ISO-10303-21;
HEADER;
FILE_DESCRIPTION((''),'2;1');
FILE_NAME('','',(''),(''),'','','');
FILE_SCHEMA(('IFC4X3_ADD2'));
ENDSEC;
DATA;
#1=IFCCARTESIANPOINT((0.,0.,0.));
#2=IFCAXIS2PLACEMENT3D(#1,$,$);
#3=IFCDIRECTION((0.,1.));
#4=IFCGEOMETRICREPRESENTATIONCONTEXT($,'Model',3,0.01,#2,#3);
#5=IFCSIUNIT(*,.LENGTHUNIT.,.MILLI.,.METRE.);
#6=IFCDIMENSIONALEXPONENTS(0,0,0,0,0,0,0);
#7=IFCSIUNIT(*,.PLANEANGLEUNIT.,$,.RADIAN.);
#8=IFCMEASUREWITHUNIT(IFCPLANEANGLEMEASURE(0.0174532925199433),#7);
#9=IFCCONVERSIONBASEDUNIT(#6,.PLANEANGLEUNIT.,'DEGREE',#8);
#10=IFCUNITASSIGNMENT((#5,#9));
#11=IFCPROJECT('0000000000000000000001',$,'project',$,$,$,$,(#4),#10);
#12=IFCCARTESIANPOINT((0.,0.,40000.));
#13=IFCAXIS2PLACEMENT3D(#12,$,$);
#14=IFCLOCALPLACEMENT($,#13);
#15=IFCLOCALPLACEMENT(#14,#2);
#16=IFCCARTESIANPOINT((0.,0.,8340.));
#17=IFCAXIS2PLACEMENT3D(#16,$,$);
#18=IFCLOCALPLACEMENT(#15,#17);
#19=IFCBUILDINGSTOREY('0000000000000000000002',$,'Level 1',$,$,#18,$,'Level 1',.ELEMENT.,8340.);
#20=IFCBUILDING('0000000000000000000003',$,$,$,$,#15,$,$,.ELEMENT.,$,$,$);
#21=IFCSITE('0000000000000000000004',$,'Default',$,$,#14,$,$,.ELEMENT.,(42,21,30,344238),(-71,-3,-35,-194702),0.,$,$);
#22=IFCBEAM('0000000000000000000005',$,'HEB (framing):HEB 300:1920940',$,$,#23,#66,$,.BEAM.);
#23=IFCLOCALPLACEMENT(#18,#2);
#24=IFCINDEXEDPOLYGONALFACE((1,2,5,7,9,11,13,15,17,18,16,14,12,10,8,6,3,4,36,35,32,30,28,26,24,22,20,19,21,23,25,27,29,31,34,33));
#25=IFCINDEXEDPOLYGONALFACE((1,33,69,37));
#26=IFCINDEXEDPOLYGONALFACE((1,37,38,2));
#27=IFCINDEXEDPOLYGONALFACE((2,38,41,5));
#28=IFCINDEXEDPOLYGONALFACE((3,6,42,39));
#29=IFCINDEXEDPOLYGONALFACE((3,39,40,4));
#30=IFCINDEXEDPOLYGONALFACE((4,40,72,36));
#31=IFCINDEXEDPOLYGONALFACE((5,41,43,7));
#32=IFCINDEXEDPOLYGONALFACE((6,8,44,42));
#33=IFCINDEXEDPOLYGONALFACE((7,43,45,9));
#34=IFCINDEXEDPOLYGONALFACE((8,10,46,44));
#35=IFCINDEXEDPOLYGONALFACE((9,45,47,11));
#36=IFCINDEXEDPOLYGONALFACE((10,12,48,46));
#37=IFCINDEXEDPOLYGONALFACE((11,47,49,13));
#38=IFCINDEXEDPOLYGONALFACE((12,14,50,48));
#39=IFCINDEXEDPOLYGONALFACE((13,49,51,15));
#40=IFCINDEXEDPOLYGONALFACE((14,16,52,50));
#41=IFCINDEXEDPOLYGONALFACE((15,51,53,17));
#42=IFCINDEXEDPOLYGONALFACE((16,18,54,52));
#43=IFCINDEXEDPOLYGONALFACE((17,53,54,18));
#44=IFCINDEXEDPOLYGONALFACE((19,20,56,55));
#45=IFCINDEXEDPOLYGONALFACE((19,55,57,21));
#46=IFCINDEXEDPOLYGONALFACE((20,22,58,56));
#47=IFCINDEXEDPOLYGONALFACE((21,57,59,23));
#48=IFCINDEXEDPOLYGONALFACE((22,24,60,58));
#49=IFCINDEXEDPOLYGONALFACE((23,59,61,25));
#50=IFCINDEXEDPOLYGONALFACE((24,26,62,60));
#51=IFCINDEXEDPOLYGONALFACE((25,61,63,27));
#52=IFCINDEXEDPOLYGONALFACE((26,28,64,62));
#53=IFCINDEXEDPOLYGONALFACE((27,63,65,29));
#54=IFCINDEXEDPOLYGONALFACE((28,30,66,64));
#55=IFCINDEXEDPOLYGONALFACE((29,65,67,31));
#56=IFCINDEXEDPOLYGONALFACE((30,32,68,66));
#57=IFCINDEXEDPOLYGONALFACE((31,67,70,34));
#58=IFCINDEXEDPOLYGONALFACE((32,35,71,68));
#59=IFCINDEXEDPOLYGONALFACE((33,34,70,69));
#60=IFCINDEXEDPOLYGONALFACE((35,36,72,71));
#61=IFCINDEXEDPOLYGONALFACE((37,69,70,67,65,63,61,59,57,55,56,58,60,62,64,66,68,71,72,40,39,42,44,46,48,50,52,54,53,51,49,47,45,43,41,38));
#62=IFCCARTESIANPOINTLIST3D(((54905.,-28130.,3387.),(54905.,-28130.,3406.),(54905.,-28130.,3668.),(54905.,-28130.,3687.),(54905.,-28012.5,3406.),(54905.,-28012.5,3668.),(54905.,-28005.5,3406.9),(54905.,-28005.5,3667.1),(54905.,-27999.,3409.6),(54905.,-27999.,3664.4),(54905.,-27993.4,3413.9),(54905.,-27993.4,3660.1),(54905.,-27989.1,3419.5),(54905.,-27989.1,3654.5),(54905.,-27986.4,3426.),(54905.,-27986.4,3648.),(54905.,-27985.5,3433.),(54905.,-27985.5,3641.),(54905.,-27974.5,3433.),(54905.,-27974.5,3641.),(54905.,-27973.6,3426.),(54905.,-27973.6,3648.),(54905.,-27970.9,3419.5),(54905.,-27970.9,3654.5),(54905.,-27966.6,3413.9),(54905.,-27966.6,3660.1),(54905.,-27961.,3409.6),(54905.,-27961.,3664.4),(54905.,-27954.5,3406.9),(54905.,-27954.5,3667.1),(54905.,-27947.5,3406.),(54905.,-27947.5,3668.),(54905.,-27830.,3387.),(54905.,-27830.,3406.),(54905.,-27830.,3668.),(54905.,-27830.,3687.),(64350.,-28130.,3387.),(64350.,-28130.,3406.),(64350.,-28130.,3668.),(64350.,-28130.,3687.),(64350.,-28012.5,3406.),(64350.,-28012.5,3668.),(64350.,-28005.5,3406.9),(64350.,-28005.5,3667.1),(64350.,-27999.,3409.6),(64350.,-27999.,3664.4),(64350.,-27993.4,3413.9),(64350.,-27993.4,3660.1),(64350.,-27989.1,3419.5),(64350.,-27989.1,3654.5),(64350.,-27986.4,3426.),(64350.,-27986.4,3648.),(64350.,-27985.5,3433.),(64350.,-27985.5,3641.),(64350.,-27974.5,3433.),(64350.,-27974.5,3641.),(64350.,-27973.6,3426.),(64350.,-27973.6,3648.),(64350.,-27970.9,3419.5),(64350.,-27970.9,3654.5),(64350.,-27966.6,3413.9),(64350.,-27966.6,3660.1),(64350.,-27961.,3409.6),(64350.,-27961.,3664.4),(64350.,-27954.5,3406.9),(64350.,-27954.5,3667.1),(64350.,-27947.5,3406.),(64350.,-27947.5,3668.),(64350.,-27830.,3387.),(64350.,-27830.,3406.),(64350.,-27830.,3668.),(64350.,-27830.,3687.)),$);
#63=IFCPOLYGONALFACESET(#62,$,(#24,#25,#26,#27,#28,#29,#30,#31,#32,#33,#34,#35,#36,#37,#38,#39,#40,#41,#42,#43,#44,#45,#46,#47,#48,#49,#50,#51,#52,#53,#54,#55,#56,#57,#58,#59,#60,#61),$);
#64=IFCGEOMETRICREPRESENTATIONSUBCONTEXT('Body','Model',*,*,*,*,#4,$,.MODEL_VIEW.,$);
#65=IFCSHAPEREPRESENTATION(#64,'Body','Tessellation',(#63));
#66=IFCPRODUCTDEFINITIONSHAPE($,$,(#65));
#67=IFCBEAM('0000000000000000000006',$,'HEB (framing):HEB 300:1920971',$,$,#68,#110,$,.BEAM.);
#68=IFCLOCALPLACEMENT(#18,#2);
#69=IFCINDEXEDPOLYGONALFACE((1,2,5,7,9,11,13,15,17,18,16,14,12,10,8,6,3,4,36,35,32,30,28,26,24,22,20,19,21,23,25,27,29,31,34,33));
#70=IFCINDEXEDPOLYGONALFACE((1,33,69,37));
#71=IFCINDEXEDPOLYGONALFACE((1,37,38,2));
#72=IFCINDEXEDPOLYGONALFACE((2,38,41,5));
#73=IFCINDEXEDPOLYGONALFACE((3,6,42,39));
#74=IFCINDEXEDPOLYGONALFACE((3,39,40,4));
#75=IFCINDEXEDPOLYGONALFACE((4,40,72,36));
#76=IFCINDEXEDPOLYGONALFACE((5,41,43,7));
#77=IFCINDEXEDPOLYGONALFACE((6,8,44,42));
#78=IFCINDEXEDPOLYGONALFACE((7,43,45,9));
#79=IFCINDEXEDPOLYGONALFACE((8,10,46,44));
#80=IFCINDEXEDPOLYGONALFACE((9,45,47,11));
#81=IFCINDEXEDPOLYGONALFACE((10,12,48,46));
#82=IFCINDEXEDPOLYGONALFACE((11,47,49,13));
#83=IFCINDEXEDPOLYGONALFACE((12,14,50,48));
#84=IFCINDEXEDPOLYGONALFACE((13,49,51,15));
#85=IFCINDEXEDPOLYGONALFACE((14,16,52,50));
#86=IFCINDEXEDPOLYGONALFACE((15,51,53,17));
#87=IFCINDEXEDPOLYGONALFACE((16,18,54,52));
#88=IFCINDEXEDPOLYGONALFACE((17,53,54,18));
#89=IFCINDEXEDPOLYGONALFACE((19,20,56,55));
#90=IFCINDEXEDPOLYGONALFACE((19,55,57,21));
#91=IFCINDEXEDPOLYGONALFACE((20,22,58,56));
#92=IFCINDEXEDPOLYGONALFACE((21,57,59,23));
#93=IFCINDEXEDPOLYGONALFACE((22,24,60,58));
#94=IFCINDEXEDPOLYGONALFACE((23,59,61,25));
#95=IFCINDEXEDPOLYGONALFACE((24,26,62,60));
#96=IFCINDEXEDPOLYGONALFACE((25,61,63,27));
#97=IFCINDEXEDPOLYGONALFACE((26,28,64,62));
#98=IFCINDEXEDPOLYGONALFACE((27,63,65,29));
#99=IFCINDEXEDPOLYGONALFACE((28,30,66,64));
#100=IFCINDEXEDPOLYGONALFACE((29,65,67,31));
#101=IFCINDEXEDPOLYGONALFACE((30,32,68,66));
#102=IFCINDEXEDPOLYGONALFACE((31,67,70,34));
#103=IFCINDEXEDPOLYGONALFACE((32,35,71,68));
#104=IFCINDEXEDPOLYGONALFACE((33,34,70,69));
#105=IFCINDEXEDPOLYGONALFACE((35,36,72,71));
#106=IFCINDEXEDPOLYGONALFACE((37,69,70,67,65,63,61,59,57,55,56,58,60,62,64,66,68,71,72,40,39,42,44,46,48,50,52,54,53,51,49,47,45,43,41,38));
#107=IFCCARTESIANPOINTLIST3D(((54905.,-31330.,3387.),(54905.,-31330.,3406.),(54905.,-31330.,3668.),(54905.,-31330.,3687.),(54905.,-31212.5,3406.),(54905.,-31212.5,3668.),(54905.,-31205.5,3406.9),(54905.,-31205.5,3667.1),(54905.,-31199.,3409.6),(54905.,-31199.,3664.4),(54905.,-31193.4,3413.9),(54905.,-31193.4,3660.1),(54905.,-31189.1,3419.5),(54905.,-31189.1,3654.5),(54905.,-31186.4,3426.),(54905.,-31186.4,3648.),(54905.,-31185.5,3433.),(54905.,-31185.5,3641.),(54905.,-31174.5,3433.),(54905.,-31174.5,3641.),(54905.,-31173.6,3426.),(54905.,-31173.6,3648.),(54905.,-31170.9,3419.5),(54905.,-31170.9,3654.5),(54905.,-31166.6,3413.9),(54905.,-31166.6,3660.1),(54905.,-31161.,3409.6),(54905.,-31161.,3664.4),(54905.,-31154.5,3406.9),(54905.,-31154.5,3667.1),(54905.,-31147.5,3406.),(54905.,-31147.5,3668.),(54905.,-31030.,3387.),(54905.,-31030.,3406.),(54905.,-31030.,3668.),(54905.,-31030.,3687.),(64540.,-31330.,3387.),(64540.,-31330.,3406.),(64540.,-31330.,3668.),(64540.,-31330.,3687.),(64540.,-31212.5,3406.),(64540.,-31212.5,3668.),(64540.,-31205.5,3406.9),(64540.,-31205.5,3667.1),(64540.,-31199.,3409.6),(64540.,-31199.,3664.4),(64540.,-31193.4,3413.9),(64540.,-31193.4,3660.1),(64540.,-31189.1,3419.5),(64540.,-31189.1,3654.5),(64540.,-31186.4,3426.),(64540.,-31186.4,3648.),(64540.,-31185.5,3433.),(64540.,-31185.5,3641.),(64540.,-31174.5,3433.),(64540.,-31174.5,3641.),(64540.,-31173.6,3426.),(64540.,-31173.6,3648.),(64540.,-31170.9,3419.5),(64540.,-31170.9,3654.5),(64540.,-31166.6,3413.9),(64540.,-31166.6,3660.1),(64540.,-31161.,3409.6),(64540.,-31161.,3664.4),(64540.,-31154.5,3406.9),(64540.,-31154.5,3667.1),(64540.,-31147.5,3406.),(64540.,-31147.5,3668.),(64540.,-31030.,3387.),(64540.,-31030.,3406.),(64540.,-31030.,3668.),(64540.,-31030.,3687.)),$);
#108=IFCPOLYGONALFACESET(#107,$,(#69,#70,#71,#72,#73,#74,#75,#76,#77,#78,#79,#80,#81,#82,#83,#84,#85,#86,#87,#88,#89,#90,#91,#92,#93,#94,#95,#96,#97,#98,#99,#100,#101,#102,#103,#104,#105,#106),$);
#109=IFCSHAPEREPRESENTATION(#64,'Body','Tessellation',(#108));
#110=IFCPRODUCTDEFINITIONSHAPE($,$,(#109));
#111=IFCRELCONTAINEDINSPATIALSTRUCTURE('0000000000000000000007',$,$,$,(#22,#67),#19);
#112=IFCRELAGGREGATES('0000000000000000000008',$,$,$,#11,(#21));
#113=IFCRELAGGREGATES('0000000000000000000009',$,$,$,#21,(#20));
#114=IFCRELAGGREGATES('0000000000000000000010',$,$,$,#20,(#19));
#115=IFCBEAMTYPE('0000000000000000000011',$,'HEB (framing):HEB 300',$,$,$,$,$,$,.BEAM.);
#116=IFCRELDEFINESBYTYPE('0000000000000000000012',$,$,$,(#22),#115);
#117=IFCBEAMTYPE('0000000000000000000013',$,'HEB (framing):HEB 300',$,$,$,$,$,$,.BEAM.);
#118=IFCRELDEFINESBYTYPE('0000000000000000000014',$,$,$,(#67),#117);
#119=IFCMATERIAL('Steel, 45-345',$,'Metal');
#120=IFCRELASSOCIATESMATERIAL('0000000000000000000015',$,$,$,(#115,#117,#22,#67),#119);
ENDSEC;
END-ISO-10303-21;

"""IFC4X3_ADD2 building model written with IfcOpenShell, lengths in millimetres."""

from ifc_helpers import new_model, entity, si_unit, converted_unit, direction, frame, frame_2d, origin, place, context, subcontext, project, spatial, polyline, circle_curve, parameter, trimmed, segment, composite_curve, outline, extrude, source, transform, mapped, material, material_profile, profile_set, profile_usage, type_object, type_shapes, element, save


model = new_model("IFC4X3_ADD2")

# Units and contexts
model_context = context("Model", 3, precision=0.01, world=origin(), true_north=direction((0.0, 1.0)))
body_context = subcontext(model_context, "Body", "Model", "MODEL_VIEW")
ifc_project = project(units=[si_unit("LENGTHUNIT", "METRE", prefix="MILLI"), converted_unit("PLANEANGLEUNIT", "DEGREE", entity("IfcPlaneAngleMeasure", 0.0174532925199433), si_unit("PLANEANGLEUNIT", "RADIAN"), dimensions=[0, 0, 0, 0, 0, 0, 0])], contexts=[model_context])

# Site, building, storey
site_placement = place(None, frame((0.0, 0.0, 40000.0)))
site = spatial("IfcSite", under=ifc_project, at=site_placement, Name="Default", CompositionType="ELEMENT", RefLatitude=(42, 21, 30, 344238), RefLongitude=(-71, -3, -35, -194702), RefElevation=0.0)
building_placement = place(site_placement, origin())
building = spatial("IfcBuilding", under=site, at=building_placement, CompositionType="ELEMENT")
storey_placement = place(building_placement, frame((0.0, 0.0, 8340.0)))
storey = spatial("IfcBuildingStorey", under=building, at=storey_placement, Name="Level 1", LongName="Level 1", CompositionType="ELEMENT", Elevation=8340.0)

# Shared definitions
ifc_material_1 = material(Name="Steel, 45-345", Category="Metal")

# Beams
ifc_material_profile_1 = material_profile(ifc_material_1, outline(composite_curve([segment(polyline([(-150.0, -131.0), (-150.0, -150.0)]), True, "CONTINUOUS"), segment(polyline([(-150.0, -150.0), (150.0, -150.0)]), True, "CONTINUOUS"), segment(polyline([(150.0, -150.0), (150.0, -131.0)]), True, "CONTINUOUS"), segment(polyline([(150.0, -131.0), (32.5, -131.0)]), True, "CONTINUOUS"), segment(trimmed(circle_curve(frame_2d((32.5, -104.0), x_axis=(1.0, 0.0)), 27.0), [parameter(180.0)], [parameter(270.0)], True, "PARAMETER"), False, "CONTINUOUS"), segment(polyline([(5.5, -104.0), (5.5, 104.0)]), True, "CONTINUOUS"), segment(trimmed(circle_curve(frame_2d((32.5, 104.0), x_axis=(1.0, 0.0)), 27.0), [parameter(90.0)], [parameter(180.0)], True, "PARAMETER"), False, "CONTINUOUS"), segment(polyline([(32.5, 131.0), (150.0, 131.0)]), True, "CONTINUOUS"), segment(polyline([(150.0, 131.0), (150.0, 150.0)]), True, "CONTINUOUS"), segment(polyline([(150.0, 150.0), (-150.0, 150.0)]), True, "CONTINUOUS"), segment(polyline([(-150.0, 150.0), (-150.0, 131.0)]), True, "CONTINUOUS"), segment(polyline([(-150.0, 131.0), (-32.5, 131.0)]), True, "CONTINUOUS"), segment(trimmed(circle_curve(frame_2d((-32.5, 104.0), x_axis=(1.0, 0.0)), 27.0), [parameter(360.0)], [parameter(90.0)], True, "PARAMETER"), False, "CONTINUOUS"), segment(polyline([(-5.5, 104.0), (-5.5, -104.0)]), True, "CONTINUOUS"), segment(trimmed(circle_curve(frame_2d((-32.5, -104.0), x_axis=(1.0, 0.0)), 27.0), [parameter(270.0)], [parameter(0.0)], True, "PARAMETER"), False, "CONTINUOUS"), segment(polyline([(-32.5, -131.0), (-150.0, -131.0)]), True, "CONTINUOUS")], self_intersect=False)), Name="HEB 300")
ifc_profile_set_1 = profile_set([ifc_material_profile_1], Name="HEB 300")
ifc_profile_usage_1 = profile_usage(ifc_profile_set_1, cardinal=8)
beam_type_1 = type_object("IfcBeamType", Name="HEB (framing):HEB 300", PredefinedType="BEAM", material=ifc_profile_set_1)
shared_shape_1 = source(origin(), body_context, "Body", "SweptSolid", [
    extrude(outline(composite_curve([segment(polyline([(-150.0, -131.0), (-150.0, -150.0)]), True, "CONTINUOUS"), segment(polyline([(-150.0, -150.0), (150.0, -150.0)]), True, "CONTINUOUS"), segment(polyline([(150.0, -150.0), (150.0, -131.0)]), True, "CONTINUOUS"), segment(polyline([(150.0, -131.0), (32.5, -131.0)]), True, "CONTINUOUS"), segment(trimmed(circle_curve(frame_2d((32.5, -104.0), x_axis=(1.0, 0.0)), 27.0), [parameter(180.0)], [parameter(270.0)], True, "PARAMETER"), False, "CONTINUOUS"), segment(polyline([(5.5, -104.0), (5.5, 104.0)]), True, "CONTINUOUS"), segment(trimmed(circle_curve(frame_2d((32.5, 104.0), x_axis=(1.0, 0.0)), 27.0), [parameter(90.0)], [parameter(180.0)], True, "PARAMETER"), False, "CONTINUOUS"), segment(polyline([(32.5, 131.0), (150.0, 131.0)]), True, "CONTINUOUS"), segment(polyline([(150.0, 131.0), (150.0, 150.0)]), True, "CONTINUOUS"), segment(polyline([(150.0, 150.0), (-150.0, 150.0)]), True, "CONTINUOUS"), segment(polyline([(-150.0, 150.0), (-150.0, 131.0)]), True, "CONTINUOUS"), segment(polyline([(-150.0, 131.0), (-32.5, 131.0)]), True, "CONTINUOUS"), segment(trimmed(circle_curve(frame_2d((-32.5, 104.0), x_axis=(1.0, 0.0)), 27.0), [parameter(360.0)], [parameter(90.0)], True, "PARAMETER"), False, "CONTINUOUS"), segment(polyline([(-5.5, 104.0), (-5.5, -104.0)]), True, "CONTINUOUS"), segment(trimmed(circle_curve(frame_2d((-32.5, -104.0), x_axis=(1.0, 0.0)), 27.0), [parameter(270.0)], [parameter(0.0)], True, "PARAMETER"), False, "CONTINUOUS"), segment(polyline([(-32.5, -131.0), (-150.0, -131.0)]), True, "CONTINUOUS")], self_intersect=False)), frame((-4697.5, 0.0, 0.0), z_axis=(-1.0, 0.0, 0.0), x_axis=(0.0, -1.0, 0.0)), (0.0, 0.0, -1.0), 9445.0),
])
type_shapes(beam_type_1, [shared_shape_1])
beam_1_placement = place(storey_placement, frame((59602.5, -27980.0, 3537.0)))
element("IfcBeam", 1, at=beam_1_placement, inside=storey, type_object=beam_type_1, material=ifc_profile_usage_1, Name="HEB (framing):HEB 300:1920940", PredefinedType="BEAM", context=body_context, shape_type="MappedRepresentation", body=[
    mapped(shared_shape_1, transform((0.0, 0.0, 0.0), scale=1.0)),
])
beam_type_2 = type_object("IfcBeamType", Name="HEB (framing):HEB 300", PredefinedType="BEAM", material=ifc_profile_set_1)
shared_shape_2 = source(origin(), body_context, "Body", "SweptSolid", [
    extrude(outline(composite_curve([segment(polyline([(-150.0, -131.0), (-150.0, -150.0)]), True, "CONTINUOUS"), segment(polyline([(-150.0, -150.0), (150.0, -150.0)]), True, "CONTINUOUS"), segment(polyline([(150.0, -150.0), (150.0, -131.0)]), True, "CONTINUOUS"), segment(polyline([(150.0, -131.0), (32.5, -131.0)]), True, "CONTINUOUS"), segment(trimmed(circle_curve(frame_2d((32.5, -104.0), x_axis=(1.0, 0.0)), 27.0), [parameter(180.0)], [parameter(270.0)], True, "PARAMETER"), False, "CONTINUOUS"), segment(polyline([(5.5, -104.0), (5.5, 104.0)]), True, "CONTINUOUS"), segment(trimmed(circle_curve(frame_2d((32.5, 104.0), x_axis=(1.0, 0.0)), 27.0), [parameter(90.0)], [parameter(180.0)], True, "PARAMETER"), False, "CONTINUOUS"), segment(polyline([(32.5, 131.0), (150.0, 131.0)]), True, "CONTINUOUS"), segment(polyline([(150.0, 131.0), (150.0, 150.0)]), True, "CONTINUOUS"), segment(polyline([(150.0, 150.0), (-150.0, 150.0)]), True, "CONTINUOUS"), segment(polyline([(-150.0, 150.0), (-150.0, 131.0)]), True, "CONTINUOUS"), segment(polyline([(-150.0, 131.0), (-32.5, 131.0)]), True, "CONTINUOUS"), segment(trimmed(circle_curve(frame_2d((-32.5, 104.0), x_axis=(1.0, 0.0)), 27.0), [parameter(360.0)], [parameter(90.0)], True, "PARAMETER"), False, "CONTINUOUS"), segment(polyline([(-5.5, 104.0), (-5.5, -104.0)]), True, "CONTINUOUS"), segment(trimmed(circle_curve(frame_2d((-32.5, -104.0), x_axis=(1.0, 0.0)), 27.0), [parameter(270.0)], [parameter(0.0)], True, "PARAMETER"), False, "CONTINUOUS"), segment(polyline([(-32.5, -131.0), (-150.0, -131.0)]), True, "CONTINUOUS")], self_intersect=False)), frame((-4697.5, 0.0, 0.0), z_axis=(-1.0, 0.0, 0.0), x_axis=(0.0, -1.0, 0.0)), (0.0, 0.0, -1.0), 9635.0),
])
type_shapes(beam_type_2, [shared_shape_2])
beam_2_placement = place(storey_placement, frame((59602.5, -31180.0, 3537.0)))
element("IfcBeam", 2, at=beam_2_placement, inside=storey, type_object=beam_type_2, material=ifc_profile_usage_1, Name="HEB (framing):HEB 300:1920971", PredefinedType="BEAM", context=body_context, shape_type="MappedRepresentation", body=[
    mapped(shared_shape_2, transform((0.0, 0.0, 0.0), scale=1.0)),
])

save(model, "model.ifc")
